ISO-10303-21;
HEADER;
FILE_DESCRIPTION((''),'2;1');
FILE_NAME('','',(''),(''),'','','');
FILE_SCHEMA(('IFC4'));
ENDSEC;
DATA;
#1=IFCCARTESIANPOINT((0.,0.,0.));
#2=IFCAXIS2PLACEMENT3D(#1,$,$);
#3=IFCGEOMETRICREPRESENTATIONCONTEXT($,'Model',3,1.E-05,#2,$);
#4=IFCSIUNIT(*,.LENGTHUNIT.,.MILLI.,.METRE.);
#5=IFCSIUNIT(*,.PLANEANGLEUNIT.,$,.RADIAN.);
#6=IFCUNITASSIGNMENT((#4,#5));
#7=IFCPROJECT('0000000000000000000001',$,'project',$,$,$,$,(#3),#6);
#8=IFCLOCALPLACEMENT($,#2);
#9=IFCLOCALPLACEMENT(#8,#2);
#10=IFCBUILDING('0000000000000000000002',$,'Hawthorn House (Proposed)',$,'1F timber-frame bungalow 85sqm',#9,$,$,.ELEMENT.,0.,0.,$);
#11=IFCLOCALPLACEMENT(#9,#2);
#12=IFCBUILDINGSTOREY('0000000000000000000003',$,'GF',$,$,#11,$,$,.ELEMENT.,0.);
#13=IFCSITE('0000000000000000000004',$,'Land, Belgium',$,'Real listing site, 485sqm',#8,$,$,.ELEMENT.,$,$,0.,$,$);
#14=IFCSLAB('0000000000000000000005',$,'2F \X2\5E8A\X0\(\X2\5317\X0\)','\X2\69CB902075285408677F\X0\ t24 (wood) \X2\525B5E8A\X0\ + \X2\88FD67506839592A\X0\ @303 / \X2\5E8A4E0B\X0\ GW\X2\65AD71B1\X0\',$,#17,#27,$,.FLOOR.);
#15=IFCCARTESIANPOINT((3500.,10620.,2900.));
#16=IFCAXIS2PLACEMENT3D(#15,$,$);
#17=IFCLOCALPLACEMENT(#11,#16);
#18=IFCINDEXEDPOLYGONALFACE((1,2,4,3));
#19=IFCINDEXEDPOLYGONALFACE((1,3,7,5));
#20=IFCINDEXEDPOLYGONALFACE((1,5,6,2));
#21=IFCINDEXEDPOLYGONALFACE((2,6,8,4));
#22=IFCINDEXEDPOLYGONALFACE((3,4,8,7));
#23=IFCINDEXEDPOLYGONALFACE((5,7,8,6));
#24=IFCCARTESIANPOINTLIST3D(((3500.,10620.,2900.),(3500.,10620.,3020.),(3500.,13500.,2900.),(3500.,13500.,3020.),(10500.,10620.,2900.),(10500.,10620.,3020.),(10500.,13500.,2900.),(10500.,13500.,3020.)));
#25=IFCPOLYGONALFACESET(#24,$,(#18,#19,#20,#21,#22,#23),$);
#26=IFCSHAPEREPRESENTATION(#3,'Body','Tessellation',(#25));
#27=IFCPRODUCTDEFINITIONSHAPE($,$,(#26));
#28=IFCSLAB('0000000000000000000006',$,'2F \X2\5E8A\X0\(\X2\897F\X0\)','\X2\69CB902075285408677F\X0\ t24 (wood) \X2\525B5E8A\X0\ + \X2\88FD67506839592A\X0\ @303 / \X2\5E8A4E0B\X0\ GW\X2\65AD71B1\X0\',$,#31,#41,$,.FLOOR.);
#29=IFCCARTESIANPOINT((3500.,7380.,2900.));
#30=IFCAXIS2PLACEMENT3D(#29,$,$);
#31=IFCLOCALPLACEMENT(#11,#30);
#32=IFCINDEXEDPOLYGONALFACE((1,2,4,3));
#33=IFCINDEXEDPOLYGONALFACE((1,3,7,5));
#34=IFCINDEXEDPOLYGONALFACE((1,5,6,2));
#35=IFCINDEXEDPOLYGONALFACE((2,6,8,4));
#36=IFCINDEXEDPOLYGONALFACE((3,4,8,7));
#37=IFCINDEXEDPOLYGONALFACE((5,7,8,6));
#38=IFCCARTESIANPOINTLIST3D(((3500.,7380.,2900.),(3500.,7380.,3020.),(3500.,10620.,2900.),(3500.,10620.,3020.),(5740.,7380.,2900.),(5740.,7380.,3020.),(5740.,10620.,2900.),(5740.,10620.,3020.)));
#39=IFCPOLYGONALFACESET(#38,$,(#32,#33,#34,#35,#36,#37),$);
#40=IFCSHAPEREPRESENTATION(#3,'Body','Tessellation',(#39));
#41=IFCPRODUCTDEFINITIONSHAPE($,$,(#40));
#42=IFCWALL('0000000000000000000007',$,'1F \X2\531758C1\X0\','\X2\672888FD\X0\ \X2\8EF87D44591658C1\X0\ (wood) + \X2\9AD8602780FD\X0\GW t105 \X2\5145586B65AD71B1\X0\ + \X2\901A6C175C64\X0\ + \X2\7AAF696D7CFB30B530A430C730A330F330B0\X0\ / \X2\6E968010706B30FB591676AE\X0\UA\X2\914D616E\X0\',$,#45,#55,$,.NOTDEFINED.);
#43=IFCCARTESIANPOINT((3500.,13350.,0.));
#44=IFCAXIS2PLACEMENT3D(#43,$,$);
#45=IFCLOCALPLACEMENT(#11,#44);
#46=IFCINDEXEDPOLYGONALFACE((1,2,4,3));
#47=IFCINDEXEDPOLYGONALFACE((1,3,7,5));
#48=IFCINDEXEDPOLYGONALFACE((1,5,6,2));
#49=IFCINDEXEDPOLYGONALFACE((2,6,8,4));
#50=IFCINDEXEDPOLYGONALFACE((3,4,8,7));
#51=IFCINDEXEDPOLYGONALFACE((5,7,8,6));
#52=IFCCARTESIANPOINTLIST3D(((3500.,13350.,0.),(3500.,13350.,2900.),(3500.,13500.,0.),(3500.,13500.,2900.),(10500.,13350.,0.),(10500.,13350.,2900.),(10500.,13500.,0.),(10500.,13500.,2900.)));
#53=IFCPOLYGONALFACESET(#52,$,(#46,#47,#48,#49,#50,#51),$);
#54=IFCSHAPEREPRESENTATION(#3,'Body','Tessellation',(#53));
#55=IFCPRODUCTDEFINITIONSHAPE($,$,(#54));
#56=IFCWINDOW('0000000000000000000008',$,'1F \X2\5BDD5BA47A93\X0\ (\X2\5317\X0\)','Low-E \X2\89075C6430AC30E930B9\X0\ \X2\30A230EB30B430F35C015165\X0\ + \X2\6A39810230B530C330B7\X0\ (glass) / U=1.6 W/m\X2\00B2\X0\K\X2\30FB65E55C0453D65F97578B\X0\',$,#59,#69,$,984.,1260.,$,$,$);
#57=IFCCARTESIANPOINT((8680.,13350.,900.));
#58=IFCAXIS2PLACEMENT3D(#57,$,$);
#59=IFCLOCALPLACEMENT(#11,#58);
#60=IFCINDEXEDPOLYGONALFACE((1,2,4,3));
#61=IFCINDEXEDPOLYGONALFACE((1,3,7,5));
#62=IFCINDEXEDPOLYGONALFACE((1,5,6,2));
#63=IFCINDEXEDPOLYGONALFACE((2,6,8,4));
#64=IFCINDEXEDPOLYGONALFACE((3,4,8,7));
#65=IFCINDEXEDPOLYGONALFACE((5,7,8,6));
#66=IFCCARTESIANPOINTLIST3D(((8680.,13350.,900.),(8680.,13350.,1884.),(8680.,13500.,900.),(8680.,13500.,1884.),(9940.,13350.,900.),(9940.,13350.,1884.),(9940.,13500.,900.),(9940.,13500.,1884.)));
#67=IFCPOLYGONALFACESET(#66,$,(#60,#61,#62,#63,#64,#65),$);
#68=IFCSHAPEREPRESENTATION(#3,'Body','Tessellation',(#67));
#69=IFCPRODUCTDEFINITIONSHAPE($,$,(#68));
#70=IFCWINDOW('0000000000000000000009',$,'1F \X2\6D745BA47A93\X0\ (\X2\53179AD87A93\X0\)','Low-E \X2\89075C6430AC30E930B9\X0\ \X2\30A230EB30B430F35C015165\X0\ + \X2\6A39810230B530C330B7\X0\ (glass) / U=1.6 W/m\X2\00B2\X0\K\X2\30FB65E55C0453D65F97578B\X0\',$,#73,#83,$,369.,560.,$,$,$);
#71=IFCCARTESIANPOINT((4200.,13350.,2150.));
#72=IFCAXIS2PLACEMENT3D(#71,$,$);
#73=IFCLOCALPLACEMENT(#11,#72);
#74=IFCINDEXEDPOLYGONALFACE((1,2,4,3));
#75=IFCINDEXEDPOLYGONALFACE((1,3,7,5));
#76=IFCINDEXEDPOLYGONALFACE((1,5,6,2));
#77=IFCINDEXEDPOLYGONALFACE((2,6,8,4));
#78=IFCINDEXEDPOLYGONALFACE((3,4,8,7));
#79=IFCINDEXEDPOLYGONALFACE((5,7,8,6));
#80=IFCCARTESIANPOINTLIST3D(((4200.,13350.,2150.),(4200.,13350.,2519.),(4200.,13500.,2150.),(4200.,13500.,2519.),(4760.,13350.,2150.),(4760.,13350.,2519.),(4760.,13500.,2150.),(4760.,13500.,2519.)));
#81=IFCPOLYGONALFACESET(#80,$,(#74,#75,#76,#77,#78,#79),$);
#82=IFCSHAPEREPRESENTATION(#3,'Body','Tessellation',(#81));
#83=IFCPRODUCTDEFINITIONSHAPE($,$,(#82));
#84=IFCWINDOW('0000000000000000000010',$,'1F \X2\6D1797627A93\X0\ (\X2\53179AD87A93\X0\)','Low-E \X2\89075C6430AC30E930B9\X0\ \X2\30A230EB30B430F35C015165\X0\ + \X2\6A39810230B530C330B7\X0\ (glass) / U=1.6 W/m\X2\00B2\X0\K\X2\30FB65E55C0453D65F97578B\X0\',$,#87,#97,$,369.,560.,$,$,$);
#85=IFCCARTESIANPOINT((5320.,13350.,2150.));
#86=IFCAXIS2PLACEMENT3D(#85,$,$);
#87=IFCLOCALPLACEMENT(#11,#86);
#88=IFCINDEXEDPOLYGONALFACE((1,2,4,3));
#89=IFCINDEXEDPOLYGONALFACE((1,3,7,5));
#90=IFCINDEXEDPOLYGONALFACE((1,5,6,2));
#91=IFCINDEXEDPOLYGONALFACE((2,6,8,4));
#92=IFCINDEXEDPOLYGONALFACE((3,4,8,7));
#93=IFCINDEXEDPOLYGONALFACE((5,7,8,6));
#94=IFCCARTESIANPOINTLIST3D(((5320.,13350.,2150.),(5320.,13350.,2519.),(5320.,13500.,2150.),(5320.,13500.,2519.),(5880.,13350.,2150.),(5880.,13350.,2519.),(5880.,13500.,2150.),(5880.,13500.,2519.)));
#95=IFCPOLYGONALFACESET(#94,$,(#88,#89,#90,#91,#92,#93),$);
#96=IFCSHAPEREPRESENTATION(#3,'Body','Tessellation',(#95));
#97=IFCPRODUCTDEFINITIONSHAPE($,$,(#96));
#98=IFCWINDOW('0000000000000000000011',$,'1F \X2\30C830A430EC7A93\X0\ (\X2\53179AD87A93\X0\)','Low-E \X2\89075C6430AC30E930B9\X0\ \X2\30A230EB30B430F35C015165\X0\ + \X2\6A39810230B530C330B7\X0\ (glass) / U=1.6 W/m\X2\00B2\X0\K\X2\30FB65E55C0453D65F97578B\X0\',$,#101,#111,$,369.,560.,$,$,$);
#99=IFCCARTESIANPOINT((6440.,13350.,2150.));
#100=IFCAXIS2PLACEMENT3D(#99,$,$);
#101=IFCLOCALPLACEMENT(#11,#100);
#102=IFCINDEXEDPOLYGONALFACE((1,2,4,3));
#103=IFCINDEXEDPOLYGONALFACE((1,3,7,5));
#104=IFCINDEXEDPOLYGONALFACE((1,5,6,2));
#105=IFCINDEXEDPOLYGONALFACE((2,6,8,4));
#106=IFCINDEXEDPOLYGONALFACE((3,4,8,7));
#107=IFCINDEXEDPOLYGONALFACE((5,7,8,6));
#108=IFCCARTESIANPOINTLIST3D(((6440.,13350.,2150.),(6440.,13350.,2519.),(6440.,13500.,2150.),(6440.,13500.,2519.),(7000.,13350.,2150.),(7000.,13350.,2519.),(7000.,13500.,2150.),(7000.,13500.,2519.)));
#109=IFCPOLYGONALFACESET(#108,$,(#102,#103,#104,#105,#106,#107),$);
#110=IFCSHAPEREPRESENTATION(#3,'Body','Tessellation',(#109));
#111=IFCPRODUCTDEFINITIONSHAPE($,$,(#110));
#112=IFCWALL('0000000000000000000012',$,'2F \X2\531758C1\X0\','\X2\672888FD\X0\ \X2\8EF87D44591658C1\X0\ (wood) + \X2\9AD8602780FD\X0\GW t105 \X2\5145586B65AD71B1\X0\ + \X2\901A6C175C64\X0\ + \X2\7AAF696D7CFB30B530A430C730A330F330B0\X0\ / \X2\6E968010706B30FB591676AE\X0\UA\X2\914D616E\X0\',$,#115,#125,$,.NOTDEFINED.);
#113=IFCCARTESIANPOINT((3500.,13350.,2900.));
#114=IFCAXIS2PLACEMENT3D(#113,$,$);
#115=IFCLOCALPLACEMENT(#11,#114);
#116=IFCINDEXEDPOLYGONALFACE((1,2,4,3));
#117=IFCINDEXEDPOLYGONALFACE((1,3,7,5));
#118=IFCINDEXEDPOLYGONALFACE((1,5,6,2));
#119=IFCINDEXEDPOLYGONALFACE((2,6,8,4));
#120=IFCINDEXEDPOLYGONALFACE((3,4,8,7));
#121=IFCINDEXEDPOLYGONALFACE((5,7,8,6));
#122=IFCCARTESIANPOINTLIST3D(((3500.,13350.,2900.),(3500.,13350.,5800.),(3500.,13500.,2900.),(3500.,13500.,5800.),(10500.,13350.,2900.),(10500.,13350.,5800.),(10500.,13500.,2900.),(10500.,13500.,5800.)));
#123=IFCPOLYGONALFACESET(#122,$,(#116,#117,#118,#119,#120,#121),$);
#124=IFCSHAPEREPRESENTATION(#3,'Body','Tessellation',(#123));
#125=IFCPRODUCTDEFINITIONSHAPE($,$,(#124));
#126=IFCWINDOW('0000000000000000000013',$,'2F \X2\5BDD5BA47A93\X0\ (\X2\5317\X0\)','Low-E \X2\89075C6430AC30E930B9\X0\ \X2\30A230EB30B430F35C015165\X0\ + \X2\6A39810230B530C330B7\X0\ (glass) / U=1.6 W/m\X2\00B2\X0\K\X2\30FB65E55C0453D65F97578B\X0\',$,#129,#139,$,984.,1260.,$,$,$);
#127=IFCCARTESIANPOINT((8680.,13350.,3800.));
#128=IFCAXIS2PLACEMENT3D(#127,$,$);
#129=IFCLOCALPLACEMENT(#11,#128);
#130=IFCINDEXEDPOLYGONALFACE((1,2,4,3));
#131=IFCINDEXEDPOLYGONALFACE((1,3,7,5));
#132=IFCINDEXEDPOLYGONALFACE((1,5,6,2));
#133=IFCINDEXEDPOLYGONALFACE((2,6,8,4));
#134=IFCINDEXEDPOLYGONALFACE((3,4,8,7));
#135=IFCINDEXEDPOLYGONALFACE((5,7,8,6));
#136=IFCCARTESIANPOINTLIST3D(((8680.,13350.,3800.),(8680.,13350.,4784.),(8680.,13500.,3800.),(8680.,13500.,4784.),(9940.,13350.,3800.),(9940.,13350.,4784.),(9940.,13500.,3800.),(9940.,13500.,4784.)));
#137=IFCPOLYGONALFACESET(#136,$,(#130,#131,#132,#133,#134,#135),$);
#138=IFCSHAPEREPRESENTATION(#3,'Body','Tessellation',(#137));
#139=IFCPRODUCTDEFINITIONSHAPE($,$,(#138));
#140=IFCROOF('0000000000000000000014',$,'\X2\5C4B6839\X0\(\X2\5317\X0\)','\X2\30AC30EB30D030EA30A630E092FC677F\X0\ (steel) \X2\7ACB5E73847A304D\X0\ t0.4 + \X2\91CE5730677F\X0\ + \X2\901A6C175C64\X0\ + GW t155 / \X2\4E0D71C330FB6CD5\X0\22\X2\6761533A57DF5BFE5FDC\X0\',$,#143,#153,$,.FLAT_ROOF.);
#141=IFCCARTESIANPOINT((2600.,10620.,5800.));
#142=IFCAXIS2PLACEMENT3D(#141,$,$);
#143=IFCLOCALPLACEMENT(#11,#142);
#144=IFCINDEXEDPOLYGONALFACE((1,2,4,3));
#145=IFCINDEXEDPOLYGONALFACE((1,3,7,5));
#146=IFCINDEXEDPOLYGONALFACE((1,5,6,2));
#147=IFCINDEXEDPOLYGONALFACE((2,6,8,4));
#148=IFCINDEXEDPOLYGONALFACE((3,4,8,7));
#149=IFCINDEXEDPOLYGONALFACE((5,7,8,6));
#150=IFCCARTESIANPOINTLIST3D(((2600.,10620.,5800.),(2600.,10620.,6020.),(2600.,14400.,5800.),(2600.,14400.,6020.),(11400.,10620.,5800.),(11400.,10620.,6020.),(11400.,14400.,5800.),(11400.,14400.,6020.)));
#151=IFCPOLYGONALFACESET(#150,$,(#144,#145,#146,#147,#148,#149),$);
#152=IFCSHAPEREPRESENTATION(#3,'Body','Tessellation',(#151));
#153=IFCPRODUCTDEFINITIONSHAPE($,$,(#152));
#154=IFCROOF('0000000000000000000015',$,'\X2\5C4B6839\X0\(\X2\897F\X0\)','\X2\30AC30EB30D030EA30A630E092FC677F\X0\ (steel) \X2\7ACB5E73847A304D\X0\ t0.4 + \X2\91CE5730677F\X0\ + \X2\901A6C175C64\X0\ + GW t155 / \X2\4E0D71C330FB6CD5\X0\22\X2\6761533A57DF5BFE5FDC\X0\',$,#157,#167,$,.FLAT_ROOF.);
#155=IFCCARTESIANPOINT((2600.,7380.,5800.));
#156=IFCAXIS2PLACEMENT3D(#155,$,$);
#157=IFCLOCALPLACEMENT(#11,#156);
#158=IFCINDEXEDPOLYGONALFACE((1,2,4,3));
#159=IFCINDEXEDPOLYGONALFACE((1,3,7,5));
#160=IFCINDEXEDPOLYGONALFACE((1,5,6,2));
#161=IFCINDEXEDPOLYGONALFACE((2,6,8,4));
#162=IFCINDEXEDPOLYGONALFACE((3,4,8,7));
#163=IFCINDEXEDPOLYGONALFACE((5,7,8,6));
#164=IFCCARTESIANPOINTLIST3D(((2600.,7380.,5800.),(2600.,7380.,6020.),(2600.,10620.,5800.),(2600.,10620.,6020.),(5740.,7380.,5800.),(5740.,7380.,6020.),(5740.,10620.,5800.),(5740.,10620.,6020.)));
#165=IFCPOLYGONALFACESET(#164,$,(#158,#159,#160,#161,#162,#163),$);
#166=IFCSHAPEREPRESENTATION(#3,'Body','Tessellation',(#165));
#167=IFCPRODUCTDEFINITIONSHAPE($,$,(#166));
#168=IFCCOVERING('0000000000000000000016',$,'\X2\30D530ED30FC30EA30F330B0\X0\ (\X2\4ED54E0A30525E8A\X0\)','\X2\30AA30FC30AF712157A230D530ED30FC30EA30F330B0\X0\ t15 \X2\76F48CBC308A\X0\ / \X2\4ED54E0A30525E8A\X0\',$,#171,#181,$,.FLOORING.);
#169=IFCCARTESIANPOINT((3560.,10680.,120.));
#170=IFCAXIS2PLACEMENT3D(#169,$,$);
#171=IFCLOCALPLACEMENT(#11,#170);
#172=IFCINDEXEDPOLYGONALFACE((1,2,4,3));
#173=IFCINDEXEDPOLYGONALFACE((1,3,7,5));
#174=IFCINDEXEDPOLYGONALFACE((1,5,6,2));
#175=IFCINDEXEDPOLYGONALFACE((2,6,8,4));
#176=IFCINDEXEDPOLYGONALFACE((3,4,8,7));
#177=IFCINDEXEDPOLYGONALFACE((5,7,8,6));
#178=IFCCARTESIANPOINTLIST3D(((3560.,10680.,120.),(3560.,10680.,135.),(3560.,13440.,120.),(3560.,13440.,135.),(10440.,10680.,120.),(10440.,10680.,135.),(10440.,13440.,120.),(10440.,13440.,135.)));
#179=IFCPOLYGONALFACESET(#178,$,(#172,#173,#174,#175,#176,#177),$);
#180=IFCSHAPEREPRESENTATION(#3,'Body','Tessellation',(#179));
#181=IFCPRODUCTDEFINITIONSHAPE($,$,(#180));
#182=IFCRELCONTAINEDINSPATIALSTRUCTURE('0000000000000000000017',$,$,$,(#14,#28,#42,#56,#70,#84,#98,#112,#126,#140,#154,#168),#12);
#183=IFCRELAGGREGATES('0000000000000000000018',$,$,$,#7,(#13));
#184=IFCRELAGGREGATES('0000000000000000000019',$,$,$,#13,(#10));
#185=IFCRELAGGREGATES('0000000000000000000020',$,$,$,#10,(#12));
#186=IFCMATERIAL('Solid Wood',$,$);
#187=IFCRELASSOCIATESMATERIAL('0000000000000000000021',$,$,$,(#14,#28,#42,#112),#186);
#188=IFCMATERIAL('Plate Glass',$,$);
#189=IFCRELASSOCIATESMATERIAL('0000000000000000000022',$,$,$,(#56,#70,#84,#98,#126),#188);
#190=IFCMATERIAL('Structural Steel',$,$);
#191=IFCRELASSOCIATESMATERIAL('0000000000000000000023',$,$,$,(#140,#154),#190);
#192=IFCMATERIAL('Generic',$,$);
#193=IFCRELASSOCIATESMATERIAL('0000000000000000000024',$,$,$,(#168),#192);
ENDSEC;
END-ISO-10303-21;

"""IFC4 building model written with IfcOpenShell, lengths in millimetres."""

from ifc_helpers import new_model, si_unit, frame, frame_2d, origin, place, context, project, spatial, rectangle, extrude, material, element, fill, save


model = new_model("IFC4")

# Units and contexts
model_context = context("Model", 3, precision=1e-05, world=origin())
ifc_project = project(units=[si_unit("LENGTHUNIT", "METRE", prefix="MILLI"), si_unit("PLANEANGLEUNIT", "RADIAN")], contexts=[model_context])

# Site, building, storey
site_placement = place(None, origin())
site = spatial("IfcSite", under=ifc_project, at=site_placement, Name="Land, Belgium", ObjectType="Real listing site, 485sqm", CompositionType="ELEMENT", RefElevation=0.0)
building_placement = place(site_placement, origin())
building = spatial("IfcBuilding", under=site, at=building_placement, Name="Hawthorn House (Proposed)", ObjectType="1F timber-frame bungalow 85sqm", CompositionType="ELEMENT", ElevationOfRefHeight=0.0, ElevationOfTerrain=0.0)
storey_placement = place(building_placement, origin())
storey = spatial("IfcBuildingStorey", under=building, at=storey_placement, Name="GF", CompositionType="ELEMENT", Elevation=0.0)

# Slabs
ifc_material_1 = material(Name="Solid Wood")
slab_1_placement = place(storey_placement, frame((3500.0, 10620.0, 2900.0)))
element("IfcSlab", 1, at=slab_1_placement, inside=storey, material=ifc_material_1, Name="2F 床(北)", Description="構造用合板 t24 (wood) 剛床 + 製材根太 @303 / 床下 GW断熱", PredefinedType="FLOOR", context=model_context, shape_type="SweptSolid", body=[
    extrude(rectangle(XDim=7000.0, YDim=2880.0, at=frame_2d((3500.0, 1440.0))), frame((3500.0, 10620.0, 2900.0)), (0.0, 0.0, 1.0), 120.0),
])
slab_2_placement = place(storey_placement, frame((3500.0, 7380.0, 2900.0)))
element("IfcSlab", 2, at=slab_2_placement, inside=storey, material=ifc_material_1, Name="2F 床(西)", Description="構造用合板 t24 (wood) 剛床 + 製材根太 @303 / 床下 GW断熱", PredefinedType="FLOOR", context=model_context, shape_type="SweptSolid", body=[
    extrude(rectangle(XDim=2240.0, YDim=3240.0, at=frame_2d((1120.0, 1620.0))), frame((3500.0, 7380.0, 2900.0)), (0.0, 0.0, 1.0), 120.0),
])

# Wall, openings, windows
wall_1_placement = place(storey_placement, frame((3500.0, 13350.0, 0.0)))
wall_1 = element("IfcWall", 3, at=wall_1_placement, inside=storey, material=ifc_material_1, Name="1F 北壁", Description="木製 軸組外壁 (wood) + 高性能GW t105 充填断熱 + 通気層 + 窯業系サイディング / 準耐火・外皮UA配慮", PredefinedType="NOTDEFINED", context=model_context, shape_type="SweptSolid", body=[
    extrude(rectangle(XDim=7000.0, YDim=150.0, at=frame_2d((3500.0, 75.0))), frame((3500.0, 13350.0, 0.0)), (0.0, 0.0, 1.0), 2900.0),
])
opening_1_placement = place(storey_placement, frame((8680.0, 13350.0, 900.0)))
opening_1 = element("IfcOpeningElement", 4, at=opening_1_placement, cuts=wall_1, PredefinedType="NOTDEFINED", context=model_context, shape_type="SweptSolid", body=[
    extrude(rectangle(XDim=1260.0, YDim=150.0, at=frame_2d((630.0, 75.0))), frame((8680.0, 13350.0, 900.0)), (0.0, 0.0, 1.0), 984.0),
])
opening_2_placement = place(storey_placement, frame((4200.0, 13350.0, 2150.0)))
opening_2 = element("IfcOpeningElement", 5, at=opening_2_placement, cuts=wall_1, PredefinedType="NOTDEFINED", context=model_context, shape_type="SweptSolid", body=[
    extrude(rectangle(XDim=560.0, YDim=150.0, at=frame_2d((280.0, 75.0))), frame((4200.0, 13350.0, 2150.0)), (0.0, 0.0, 1.0), 369.0),
])
opening_3_placement = place(storey_placement, frame((5320.0, 13350.0, 2150.0)))
opening_3 = element("IfcOpeningElement", 6, at=opening_3_placement, cuts=wall_1, PredefinedType="NOTDEFINED", context=model_context, shape_type="SweptSolid", body=[
    extrude(rectangle(XDim=560.0, YDim=150.0, at=frame_2d((280.0, 75.0))), frame((5320.0, 13350.0, 2150.0)), (0.0, 0.0, 1.0), 369.0),
])
opening_4_placement = place(storey_placement, frame((6440.0, 13350.0, 2150.0)))
opening_4 = element("IfcOpeningElement", 7, at=opening_4_placement, cuts=wall_1, PredefinedType="NOTDEFINED", context=model_context, shape_type="SweptSolid", body=[
    extrude(rectangle(XDim=560.0, YDim=150.0, at=frame_2d((280.0, 75.0))), frame((6440.0, 13350.0, 2150.0)), (0.0, 0.0, 1.0), 369.0),
])
ifc_material_2 = material(Name="Plate Glass")
window_1_placement = place(storey_placement, frame((8680.0, 13350.0, 900.0)))
window_1 = element("IfcWindow", 8, at=window_1_placement, inside=storey, material=ifc_material_2, Name="1F 寝室窓 (北)", Description="Low-E 複層ガラス アルゴン封入 + 樹脂サッシ (glass) / U=1.6 W/m²K・日射取得型", OverallHeight=984.0, OverallWidth=1260.0, context=model_context, shape_type="SweptSolid", body=[
    extrude(rectangle(XDim=1260.0, YDim=150.0, at=frame_2d((630.0, 75.0))), frame((8680.0, 13350.0, 900.0)), (0.0, 0.0, 1.0), 984.0),
])
fill(opening_1, window_1)
window_2_placement = place(storey_placement, frame((4200.0, 13350.0, 2150.0)))
window_2 = element("IfcWindow", 9, at=window_2_placement, inside=storey, material=ifc_material_2, Name="1F 浴室窓 (北高窓)", Description="Low-E 複層ガラス アルゴン封入 + 樹脂サッシ (glass) / U=1.6 W/m²K・日射取得型", OverallHeight=369.0, OverallWidth=560.0, context=model_context, shape_type="SweptSolid", body=[
    extrude(rectangle(XDim=560.0, YDim=150.0, at=frame_2d((280.0, 75.0))), frame((4200.0, 13350.0, 2150.0)), (0.0, 0.0, 1.0), 369.0),
])
fill(opening_2, window_2)
window_3_placement = place(storey_placement, frame((5320.0, 13350.0, 2150.0)))
window_3 = element("IfcWindow", 10, at=window_3_placement, inside=storey, material=ifc_material_2, Name="1F 洗面窓 (北高窓)", Description="Low-E 複層ガラス アルゴン封入 + 樹脂サッシ (glass) / U=1.6 W/m²K・日射取得型", OverallHeight=369.0, OverallWidth=560.0, context=model_context, shape_type="SweptSolid", body=[
    extrude(rectangle(XDim=560.0, YDim=150.0, at=frame_2d((280.0, 75.0))), frame((5320.0, 13350.0, 2150.0)), (0.0, 0.0, 1.0), 369.0),
])
fill(opening_3, window_3)
window_4_placement = place(storey_placement, frame((6440.0, 13350.0, 2150.0)))
window_4 = element("IfcWindow", 11, at=window_4_placement, inside=storey, material=ifc_material_2, Name="1F トイレ窓 (北高窓)", Description="Low-E 複層ガラス アルゴン封入 + 樹脂サッシ (glass) / U=1.6 W/m²K・日射取得型", OverallHeight=369.0, OverallWidth=560.0, context=model_context, shape_type="SweptSolid", body=[
    extrude(rectangle(XDim=560.0, YDim=150.0, at=frame_2d((280.0, 75.0))), frame((6440.0, 13350.0, 2150.0)), (0.0, 0.0, 1.0), 369.0),
])
fill(opening_4, window_4)

# Wall, opening, window
wall_2_placement = place(storey_placement, frame((3500.0, 13350.0, 2900.0)))
wall_2 = element("IfcWall", 12, at=wall_2_placement, inside=storey, material=ifc_material_1, Name="2F 北壁", Description="木製 軸組外壁 (wood) + 高性能GW t105 充填断熱 + 通気層 + 窯業系サイディング / 準耐火・外皮UA配慮", PredefinedType="NOTDEFINED", context=model_context, shape_type="SweptSolid", body=[
    extrude(rectangle(XDim=7000.0, YDim=150.0, at=frame_2d((3500.0, 75.0))), frame((3500.0, 13350.0, 2900.0)), (0.0, 0.0, 1.0), 2900.0),
])
opening_5_placement = place(storey_placement, frame((8680.0, 13350.0, 3800.0)))
opening_5 = element("IfcOpeningElement", 13, at=opening_5_placement, cuts=wall_2, PredefinedType="NOTDEFINED", context=model_context, shape_type="SweptSolid", body=[
    extrude(rectangle(XDim=1260.0, YDim=150.0, at=frame_2d((630.0, 75.0))), frame((8680.0, 13350.0, 3800.0)), (0.0, 0.0, 1.0), 984.0),
])
window_5_placement = place(storey_placement, frame((8680.0, 13350.0, 3800.0)))
window_5 = element("IfcWindow", 14, at=window_5_placement, inside=storey, material=ifc_material_2, Name="2F 寝室窓 (北)", Description="Low-E 複層ガラス アルゴン封入 + 樹脂サッシ (glass) / U=1.6 W/m²K・日射取得型", OverallHeight=984.0, OverallWidth=1260.0, context=model_context, shape_type="SweptSolid", body=[
    extrude(rectangle(XDim=1260.0, YDim=150.0, at=frame_2d((630.0, 75.0))), frame((8680.0, 13350.0, 3800.0)), (0.0, 0.0, 1.0), 984.0),
])
fill(opening_5, window_5)

# Roofs
ifc_material_3 = material(Name="Structural Steel")
for number, where, name in (
    (15, (2600.0, 10620.0, 5800.0), "屋根(北)"),
):
    element("IfcRoof", number, at=place(storey_placement, frame(where)), inside=storey, material=ifc_material_3, Name=name, Description="ガルバリウム鋼板 (steel) 立平葺き t0.4 + 野地板 + 通気層 + GW t155 / 不燃・法22条区域対応", PredefinedType="FLAT_ROOF", context=model_context, shape_type="SweptSolid", body=[
        extrude(rectangle(XDim=8800.0, YDim=3780.0, at=frame_2d((4400.0, 1890.0))), frame((2600.0, 10620.0, 5800.0)), (0.0, 0.0, 1.0), 220.0),
    ])
roof_placement = place(storey_placement, frame((2600.0, 7380.0, 5800.0)))
element("IfcRoof", 16, at=roof_placement, inside=storey, material=ifc_material_3, Name="屋根(西)", Description="ガルバリウム鋼板 (steel) 立平葺き t0.4 + 野地板 + 通気層 + GW t155 / 不燃・法22条区域対応", PredefinedType="FLAT_ROOF", context=model_context, shape_type="SweptSolid", body=[
    extrude(rectangle(XDim=3140.0, YDim=3240.0, at=frame_2d((1570.0, 1620.0))), frame((2600.0, 7380.0, 5800.0)), (0.0, 0.0, 1.0), 220.0),
])

# Covering
ifc_material_4 = material(Name="Generic")
covering_1_placement = place(storey_placement, frame((3560.0, 10680.0, 120.0)))
element("IfcCovering", 17, at=covering_1_placement, inside=storey, material=ifc_material_4, Name="フローリング (仕上げ床)", Description="オーク無垢フローリング t15 直貼り / 仕上げ床", PredefinedType="FLOORING", context=model_context, shape_type="SweptSolid", body=[
    extrude(rectangle(XDim=6880.0, YDim=2760.0, at=frame_2d((3440.0, 1380.0))), frame((3560.0, 10680.0, 120.0)), (0.0, 0.0, 1.0), 15.0),
])

save(model, "model.ifc")
